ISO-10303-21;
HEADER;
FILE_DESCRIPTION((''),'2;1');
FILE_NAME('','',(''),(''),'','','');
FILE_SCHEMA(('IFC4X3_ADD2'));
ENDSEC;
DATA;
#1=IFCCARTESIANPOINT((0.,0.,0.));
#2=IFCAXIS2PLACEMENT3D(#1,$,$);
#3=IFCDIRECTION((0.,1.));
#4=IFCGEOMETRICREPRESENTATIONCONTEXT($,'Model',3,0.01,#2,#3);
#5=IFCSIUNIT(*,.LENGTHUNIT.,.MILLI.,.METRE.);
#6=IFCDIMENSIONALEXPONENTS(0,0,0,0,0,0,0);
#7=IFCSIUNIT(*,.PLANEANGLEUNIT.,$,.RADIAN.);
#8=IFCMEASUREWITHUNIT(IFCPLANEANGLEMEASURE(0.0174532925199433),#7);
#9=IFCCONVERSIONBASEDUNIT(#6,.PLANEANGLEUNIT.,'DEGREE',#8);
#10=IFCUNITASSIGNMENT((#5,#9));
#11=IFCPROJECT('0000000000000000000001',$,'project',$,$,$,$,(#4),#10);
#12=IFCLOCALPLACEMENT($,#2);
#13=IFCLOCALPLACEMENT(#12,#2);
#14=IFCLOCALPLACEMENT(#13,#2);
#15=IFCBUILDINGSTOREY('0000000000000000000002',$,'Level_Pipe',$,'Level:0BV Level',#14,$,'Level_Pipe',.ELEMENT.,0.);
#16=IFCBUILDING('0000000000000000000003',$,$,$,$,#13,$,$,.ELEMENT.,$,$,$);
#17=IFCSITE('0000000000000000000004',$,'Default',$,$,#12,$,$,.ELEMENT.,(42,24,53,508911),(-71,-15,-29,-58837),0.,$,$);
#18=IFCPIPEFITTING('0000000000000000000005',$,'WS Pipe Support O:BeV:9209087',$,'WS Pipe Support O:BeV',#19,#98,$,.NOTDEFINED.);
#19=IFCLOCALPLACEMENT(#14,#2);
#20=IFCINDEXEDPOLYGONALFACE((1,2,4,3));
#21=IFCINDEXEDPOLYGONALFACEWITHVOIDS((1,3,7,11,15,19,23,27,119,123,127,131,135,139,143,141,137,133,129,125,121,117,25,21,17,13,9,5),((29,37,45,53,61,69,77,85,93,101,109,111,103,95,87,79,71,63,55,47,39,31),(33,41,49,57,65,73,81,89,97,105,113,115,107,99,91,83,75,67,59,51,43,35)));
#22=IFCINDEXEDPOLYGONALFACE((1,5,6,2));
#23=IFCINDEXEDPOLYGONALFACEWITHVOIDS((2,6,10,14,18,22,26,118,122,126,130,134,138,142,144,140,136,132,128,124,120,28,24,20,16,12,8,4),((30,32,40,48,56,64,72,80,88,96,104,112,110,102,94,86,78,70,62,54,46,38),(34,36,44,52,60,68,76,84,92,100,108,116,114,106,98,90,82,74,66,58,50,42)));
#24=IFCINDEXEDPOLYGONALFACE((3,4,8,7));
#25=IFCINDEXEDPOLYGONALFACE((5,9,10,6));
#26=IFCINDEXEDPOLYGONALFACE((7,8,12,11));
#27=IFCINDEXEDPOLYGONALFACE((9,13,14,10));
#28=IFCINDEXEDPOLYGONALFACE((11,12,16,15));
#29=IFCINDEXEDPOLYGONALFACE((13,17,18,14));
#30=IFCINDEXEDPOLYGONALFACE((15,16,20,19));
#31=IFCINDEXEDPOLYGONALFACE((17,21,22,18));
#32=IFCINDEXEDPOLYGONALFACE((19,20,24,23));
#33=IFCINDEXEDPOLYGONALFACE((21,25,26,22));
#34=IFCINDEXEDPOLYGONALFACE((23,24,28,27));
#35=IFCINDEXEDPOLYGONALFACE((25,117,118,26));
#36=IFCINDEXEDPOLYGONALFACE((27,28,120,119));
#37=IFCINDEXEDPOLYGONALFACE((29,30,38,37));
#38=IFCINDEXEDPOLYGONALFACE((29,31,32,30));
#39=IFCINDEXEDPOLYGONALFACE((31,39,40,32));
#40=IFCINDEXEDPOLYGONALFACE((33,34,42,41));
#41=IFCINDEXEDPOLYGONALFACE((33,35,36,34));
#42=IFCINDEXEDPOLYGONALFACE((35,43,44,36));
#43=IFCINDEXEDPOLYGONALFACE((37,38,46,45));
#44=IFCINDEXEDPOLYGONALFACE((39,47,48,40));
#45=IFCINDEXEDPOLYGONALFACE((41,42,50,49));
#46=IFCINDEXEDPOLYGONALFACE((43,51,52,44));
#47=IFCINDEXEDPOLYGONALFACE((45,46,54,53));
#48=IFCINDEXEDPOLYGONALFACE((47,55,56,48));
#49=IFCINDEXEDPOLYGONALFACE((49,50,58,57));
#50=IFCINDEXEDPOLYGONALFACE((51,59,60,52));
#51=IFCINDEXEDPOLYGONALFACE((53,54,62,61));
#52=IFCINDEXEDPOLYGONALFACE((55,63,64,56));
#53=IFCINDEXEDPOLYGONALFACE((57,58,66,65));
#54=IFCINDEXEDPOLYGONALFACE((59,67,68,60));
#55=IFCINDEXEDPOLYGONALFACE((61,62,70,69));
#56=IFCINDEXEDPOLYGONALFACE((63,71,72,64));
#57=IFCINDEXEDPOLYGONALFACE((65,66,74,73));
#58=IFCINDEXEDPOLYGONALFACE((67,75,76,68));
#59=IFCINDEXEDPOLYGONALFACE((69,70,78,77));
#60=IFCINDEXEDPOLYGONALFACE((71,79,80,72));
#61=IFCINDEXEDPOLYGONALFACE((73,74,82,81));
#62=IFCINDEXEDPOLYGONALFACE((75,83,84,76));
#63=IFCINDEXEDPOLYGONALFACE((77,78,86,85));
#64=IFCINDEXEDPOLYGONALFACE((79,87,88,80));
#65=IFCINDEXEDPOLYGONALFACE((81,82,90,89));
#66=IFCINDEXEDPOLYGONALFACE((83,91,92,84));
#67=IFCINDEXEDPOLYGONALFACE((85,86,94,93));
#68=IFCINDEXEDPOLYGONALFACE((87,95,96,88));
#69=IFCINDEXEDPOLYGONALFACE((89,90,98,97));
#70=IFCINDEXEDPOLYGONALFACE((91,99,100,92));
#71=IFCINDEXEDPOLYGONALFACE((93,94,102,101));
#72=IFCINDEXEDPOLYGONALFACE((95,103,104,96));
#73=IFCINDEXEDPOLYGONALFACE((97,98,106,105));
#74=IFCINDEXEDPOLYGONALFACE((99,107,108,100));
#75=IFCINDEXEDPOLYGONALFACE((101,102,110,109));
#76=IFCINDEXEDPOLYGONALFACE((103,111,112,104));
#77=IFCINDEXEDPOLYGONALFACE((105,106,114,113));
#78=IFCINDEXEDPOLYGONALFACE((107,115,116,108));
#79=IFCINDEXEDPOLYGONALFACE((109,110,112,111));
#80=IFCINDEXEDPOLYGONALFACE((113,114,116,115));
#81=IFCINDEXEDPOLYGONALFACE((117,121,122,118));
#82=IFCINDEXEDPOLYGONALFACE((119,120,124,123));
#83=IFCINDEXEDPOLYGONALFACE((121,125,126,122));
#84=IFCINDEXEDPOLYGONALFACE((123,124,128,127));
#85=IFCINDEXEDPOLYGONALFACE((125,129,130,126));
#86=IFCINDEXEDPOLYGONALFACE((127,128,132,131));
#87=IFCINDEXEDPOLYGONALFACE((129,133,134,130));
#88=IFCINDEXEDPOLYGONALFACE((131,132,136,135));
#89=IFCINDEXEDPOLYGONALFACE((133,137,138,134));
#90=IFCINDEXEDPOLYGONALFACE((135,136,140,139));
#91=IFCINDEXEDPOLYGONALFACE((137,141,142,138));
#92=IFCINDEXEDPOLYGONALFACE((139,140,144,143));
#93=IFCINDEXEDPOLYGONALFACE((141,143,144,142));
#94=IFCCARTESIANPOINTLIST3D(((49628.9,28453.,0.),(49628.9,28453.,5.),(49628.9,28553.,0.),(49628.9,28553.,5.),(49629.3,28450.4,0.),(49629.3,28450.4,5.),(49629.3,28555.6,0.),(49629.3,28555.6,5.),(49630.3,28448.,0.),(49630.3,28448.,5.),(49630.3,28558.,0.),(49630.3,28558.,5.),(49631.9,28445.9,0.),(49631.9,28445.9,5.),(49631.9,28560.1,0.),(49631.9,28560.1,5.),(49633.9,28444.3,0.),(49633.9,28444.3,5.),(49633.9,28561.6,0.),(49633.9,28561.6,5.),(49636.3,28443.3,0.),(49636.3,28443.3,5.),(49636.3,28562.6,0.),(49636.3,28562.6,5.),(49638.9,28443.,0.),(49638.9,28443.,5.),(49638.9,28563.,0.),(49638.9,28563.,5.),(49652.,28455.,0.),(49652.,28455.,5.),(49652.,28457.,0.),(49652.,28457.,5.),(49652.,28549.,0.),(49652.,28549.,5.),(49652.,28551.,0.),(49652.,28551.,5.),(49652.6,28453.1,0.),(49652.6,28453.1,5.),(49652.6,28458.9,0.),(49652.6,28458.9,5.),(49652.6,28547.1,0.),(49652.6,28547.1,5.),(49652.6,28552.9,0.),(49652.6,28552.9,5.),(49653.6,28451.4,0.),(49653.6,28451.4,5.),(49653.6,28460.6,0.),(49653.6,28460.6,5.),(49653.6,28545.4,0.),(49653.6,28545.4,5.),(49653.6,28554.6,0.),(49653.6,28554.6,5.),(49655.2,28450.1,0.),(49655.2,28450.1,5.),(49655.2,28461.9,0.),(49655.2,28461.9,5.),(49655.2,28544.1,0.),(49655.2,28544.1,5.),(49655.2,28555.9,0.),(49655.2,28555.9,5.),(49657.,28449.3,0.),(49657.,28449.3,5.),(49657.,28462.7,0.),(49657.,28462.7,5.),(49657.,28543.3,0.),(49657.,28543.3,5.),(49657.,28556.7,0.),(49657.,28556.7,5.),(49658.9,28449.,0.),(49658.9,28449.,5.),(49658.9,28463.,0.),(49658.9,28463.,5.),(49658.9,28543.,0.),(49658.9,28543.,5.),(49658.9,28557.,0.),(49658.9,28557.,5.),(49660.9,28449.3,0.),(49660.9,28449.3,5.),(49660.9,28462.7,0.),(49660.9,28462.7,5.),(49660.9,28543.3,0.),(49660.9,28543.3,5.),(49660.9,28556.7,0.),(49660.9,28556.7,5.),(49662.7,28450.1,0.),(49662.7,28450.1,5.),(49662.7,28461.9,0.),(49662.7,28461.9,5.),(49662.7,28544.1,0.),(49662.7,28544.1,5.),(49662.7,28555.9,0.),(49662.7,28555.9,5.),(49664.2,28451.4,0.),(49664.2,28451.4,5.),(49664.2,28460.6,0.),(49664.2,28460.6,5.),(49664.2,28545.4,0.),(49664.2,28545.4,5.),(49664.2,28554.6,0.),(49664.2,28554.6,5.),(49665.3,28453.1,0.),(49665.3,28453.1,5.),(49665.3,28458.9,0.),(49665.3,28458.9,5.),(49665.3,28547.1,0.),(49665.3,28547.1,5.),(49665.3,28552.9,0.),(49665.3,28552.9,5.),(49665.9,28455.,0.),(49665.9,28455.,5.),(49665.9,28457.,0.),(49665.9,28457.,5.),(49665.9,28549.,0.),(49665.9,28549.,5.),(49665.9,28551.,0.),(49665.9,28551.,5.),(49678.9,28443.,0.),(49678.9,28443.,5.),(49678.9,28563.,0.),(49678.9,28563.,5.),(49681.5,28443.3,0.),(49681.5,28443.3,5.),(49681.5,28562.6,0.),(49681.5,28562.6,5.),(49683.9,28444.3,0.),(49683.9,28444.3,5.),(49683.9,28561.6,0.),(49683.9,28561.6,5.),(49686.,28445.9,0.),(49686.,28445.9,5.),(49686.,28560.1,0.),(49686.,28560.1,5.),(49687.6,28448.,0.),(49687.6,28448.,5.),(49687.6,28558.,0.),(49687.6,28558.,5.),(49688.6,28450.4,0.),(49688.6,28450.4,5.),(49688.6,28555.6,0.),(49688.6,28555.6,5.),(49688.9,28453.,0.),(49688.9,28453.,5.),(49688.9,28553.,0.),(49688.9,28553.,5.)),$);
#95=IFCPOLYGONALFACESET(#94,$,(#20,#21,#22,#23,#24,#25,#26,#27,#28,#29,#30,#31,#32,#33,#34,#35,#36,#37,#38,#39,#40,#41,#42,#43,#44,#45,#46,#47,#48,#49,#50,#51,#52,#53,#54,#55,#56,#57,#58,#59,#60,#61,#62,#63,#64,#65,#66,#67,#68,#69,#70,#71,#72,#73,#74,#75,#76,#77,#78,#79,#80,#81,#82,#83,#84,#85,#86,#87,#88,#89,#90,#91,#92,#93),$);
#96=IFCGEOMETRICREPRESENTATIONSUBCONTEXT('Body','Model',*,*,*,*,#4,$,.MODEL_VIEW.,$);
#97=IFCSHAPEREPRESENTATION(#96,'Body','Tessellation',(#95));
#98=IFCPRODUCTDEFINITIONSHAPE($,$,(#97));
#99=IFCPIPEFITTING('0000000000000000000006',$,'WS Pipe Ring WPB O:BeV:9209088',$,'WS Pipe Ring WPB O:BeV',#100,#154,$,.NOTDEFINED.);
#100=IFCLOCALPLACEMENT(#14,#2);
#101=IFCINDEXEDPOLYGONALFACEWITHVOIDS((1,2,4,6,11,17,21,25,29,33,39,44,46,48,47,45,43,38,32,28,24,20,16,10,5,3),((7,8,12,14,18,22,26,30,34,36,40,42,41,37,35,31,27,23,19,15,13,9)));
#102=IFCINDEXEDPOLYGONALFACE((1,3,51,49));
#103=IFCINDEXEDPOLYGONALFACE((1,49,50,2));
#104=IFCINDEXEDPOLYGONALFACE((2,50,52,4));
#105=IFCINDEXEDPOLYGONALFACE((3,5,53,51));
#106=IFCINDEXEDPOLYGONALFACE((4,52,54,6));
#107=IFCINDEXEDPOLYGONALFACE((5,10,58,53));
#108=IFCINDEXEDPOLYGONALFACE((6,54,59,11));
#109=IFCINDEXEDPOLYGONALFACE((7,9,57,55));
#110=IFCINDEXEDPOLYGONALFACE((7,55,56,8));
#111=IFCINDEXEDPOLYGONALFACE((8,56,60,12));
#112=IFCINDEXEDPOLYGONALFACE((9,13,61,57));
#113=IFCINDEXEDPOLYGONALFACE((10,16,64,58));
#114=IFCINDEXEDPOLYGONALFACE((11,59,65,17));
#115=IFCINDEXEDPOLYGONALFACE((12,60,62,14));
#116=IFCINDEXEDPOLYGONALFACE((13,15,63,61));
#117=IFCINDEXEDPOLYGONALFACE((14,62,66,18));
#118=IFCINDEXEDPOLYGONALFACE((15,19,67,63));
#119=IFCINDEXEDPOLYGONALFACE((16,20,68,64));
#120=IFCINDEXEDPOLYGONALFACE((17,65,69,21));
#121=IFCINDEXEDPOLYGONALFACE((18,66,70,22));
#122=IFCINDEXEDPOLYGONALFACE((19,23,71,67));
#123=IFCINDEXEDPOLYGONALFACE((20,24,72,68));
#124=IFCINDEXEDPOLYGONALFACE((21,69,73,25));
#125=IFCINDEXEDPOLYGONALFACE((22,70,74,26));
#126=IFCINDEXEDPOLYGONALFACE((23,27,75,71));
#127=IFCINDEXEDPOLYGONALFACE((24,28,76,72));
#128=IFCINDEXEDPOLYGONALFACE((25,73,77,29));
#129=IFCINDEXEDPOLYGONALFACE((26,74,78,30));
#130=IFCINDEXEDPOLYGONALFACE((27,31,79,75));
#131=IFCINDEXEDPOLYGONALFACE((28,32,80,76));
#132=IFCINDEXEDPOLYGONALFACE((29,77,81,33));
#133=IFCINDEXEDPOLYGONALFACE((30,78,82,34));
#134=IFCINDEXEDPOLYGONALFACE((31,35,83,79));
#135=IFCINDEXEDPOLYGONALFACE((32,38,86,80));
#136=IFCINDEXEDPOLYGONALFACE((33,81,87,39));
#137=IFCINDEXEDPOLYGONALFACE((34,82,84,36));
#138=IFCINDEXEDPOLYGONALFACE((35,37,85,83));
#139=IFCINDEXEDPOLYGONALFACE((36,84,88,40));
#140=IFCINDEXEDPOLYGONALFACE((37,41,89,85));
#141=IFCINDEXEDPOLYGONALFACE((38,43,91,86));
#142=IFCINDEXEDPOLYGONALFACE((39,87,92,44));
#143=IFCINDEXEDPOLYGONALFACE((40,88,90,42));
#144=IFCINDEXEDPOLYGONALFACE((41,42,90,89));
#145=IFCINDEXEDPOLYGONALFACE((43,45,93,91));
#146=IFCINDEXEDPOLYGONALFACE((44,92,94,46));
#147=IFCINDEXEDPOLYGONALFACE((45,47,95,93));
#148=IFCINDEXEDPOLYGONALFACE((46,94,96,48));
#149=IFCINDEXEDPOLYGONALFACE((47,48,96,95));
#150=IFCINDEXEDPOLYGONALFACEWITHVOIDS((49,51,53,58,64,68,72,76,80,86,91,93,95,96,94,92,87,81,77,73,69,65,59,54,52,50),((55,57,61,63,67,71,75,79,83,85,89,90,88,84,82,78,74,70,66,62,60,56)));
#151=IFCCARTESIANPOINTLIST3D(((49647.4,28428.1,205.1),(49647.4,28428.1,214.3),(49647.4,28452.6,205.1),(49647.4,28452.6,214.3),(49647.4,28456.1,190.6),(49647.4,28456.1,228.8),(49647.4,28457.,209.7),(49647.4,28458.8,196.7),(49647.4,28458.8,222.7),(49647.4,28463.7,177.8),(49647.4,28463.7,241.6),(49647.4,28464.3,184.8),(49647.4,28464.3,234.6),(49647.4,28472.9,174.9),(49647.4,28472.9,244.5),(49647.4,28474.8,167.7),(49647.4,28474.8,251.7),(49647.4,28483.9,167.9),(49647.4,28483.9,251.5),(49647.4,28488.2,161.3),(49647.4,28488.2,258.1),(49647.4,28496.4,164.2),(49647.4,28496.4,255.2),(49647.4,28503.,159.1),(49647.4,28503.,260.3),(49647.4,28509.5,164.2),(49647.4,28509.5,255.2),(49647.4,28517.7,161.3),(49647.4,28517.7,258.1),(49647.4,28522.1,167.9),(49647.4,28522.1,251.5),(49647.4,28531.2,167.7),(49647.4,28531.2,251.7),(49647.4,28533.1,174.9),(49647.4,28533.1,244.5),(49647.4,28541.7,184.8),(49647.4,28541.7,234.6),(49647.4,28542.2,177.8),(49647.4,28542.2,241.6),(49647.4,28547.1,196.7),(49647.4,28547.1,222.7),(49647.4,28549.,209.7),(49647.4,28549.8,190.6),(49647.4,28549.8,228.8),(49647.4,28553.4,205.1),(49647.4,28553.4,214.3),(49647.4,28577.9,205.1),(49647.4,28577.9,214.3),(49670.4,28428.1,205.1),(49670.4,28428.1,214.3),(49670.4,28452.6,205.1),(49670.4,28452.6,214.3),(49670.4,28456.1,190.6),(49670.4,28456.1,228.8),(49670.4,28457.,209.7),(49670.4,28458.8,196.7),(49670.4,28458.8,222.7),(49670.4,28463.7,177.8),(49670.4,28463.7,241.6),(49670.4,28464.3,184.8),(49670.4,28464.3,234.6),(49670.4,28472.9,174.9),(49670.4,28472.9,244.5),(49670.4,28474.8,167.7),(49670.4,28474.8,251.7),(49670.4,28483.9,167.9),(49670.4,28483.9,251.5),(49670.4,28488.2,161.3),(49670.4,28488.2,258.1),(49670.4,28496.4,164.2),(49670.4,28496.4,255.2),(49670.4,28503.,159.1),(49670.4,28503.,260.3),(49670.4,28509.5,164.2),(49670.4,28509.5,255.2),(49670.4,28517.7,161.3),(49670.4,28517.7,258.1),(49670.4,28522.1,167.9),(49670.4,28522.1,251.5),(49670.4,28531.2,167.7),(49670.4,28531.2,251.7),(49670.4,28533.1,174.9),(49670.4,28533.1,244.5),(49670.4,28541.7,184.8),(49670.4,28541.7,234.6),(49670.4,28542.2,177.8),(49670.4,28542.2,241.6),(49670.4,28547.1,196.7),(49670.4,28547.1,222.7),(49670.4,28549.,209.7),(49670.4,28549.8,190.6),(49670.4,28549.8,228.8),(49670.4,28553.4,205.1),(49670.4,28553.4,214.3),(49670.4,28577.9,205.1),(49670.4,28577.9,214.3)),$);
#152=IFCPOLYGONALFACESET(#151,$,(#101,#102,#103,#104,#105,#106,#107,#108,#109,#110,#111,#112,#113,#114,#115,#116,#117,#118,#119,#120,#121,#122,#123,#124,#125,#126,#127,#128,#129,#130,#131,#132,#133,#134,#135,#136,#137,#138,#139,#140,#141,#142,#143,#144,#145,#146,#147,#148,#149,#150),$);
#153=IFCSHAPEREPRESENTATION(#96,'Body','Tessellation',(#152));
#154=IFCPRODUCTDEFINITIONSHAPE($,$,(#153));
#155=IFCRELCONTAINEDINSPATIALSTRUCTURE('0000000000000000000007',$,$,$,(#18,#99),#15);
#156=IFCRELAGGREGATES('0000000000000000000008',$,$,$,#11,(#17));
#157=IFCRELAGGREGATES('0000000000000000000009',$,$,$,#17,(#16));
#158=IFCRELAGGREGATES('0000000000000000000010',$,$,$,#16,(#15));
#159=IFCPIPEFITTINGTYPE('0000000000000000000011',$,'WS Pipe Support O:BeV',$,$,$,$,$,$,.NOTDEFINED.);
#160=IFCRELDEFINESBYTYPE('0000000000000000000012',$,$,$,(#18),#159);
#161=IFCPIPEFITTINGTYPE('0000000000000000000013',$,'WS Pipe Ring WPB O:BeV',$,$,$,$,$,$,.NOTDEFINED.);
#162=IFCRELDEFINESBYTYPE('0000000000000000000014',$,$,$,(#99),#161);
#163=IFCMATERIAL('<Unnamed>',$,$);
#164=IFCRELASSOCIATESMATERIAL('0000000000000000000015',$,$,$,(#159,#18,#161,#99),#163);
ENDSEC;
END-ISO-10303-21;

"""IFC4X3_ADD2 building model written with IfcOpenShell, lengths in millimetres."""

from ifc_helpers import new_model, entity, si_unit, converted_unit, direction, frame, frame_2d, origin, origin_2d_with_axis, place, context, subcontext, project, spatial, polyline, circle_curve, parameter, trimmed, segment, composite_curve, outline, extrude, source, transform, mapped, material, type_object, type_shapes, element, save


model = new_model("IFC4X3_ADD2")

# Units and contexts
model_context = context("Model", 3, precision=0.01, world=origin(), true_north=direction((0.0, 1.0)))
body_context = subcontext(model_context, "Body", "Model", "MODEL_VIEW")
ifc_project = project(units=[si_unit("LENGTHUNIT", "METRE", prefix="MILLI"), converted_unit("PLANEANGLEUNIT", "DEGREE", entity("IfcPlaneAngleMeasure", 0.0174532925199433), si_unit("PLANEANGLEUNIT", "RADIAN"), dimensions=[0, 0, 0, 0, 0, 0, 0])], contexts=[model_context])

# Site, building, storey
site_placement = place(None, origin())
site = spatial("IfcSite", under=ifc_project, at=site_placement, Name="Default", CompositionType="ELEMENT", RefLatitude=(42, 24, 53, 508911), RefLongitude=(-71, -15, -29, -58837), RefElevation=0.0)
building_placement = place(site_placement, origin())
building = spatial("IfcBuilding", under=site, at=building_placement, CompositionType="ELEMENT")
storey_placement = place(building_placement, origin())
storey = spatial("IfcBuildingStorey", under=building, at=storey_placement, Name="Level_Pipe", ObjectType="Level:0BV Level", LongName="Level_Pipe", CompositionType="ELEMENT", Elevation=0.0)

# Pipe fittings
ifc_material_1 = material(Name="<Unnamed>")
pipe_fitting_type_1 = type_object("IfcPipeFittingType", Name="WS Pipe Support O:BeV", PredefinedType="NOTDEFINED", material=ifc_material_1)
shared_shape_1 = source(origin(), body_context, "Body", "SweptSolid", [
    extrude(outline(composite_curve([segment(trimmed(circle_curve(frame_2d((50.0, -20.0), x_axis=(1.0, 0.0)), 10.0), [parameter(270.0)], [parameter(0.0)], True, "PARAMETER"), True, "CONTINUOUS"), segment(polyline([(60.0, -20.0), (60.0, 20.0)]), True, "CONTINUOUS"), segment(trimmed(circle_curve(frame_2d((50.0, 20.0), x_axis=(1.0, 0.0)), 10.0), [parameter(0.0)], [parameter(90.0)], True, "PARAMETER"), True, "CONTINUOUS"), segment(polyline([(50.0, 30.0), (-50.0, 30.0)]), True, "CONTINUOUS"), segment(trimmed(circle_curve(frame_2d((-50.0, 20.0), x_axis=(1.0, 0.0)), 10.0), [parameter(90.0)], [parameter(180.0)], True, "PARAMETER"), True, "CONTINUOUS"), segment(polyline([(-60.0, 20.0), (-60.0, -20.0)]), True, "CONTINUOUS"), segment(trimmed(circle_curve(frame_2d((-50.0, -20.0), x_axis=(1.0, 0.0)), 10.0), [parameter(180.0)], [parameter(270.0)], True, "PARAMETER"), True, "CONTINUOUS"), segment(polyline([(-50.0, -30.0), (50.0, -30.0)]), True, "CONTINUOUS")], self_intersect=False), holes=[composite_curve([segment(trimmed(circle_curve(frame_2d((-47.0, 0.0), x_axis=(1.0, 0.0)), 7.0), [parameter(0.0)], [parameter(180.0)], True, "PARAMETER"), False, "CONTINUOUS"), segment(trimmed(circle_curve(frame_2d((-47.0, 0.0), x_axis=(1.0, 0.0)), 7.0), [parameter(180.0)], [parameter(360.0)], True, "PARAMETER"), False, "CONTINUOUS")], self_intersect=False), composite_curve([segment(trimmed(circle_curve(frame_2d((47.0, 0.0), x_axis=(1.0, 0.0)), 7.0), [parameter(0.0)], [parameter(180.0)], True, "PARAMETER"), False, "CONTINUOUS"), segment(trimmed(circle_curve(frame_2d((47.0, 0.0), x_axis=(1.0, 0.0)), 7.0), [parameter(180.0)], [parameter(360.0)], True, "PARAMETER"), False, "CONTINUOUS")], self_intersect=False)]), origin(), (0.0, 0.0, 1.0), 5.0),
])
type_shapes(pipe_fitting_type_1, [shared_shape_1])
pipe_fitting_1_placement = place(storey_placement, frame((49658.9, 28503.0, 0.0), z_axis=(0.0, 0.0, 1.0), x_axis=(0.0, -1.0, 0.0)))
element("IfcPipeFitting", 1, at=pipe_fitting_1_placement, inside=storey, type_object=pipe_fitting_type_1, material=ifc_material_1, Name="WS Pipe Support O:BeV:9209087", ObjectType="WS Pipe Support O:BeV", PredefinedType="NOTDEFINED", context=body_context, shape_type="MappedRepresentation", body=[
    mapped(shared_shape_1, transform((0.0, 0.0, 0.0), scale=1.0)),
])
pipe_fitting_type_2 = type_object("IfcPipeFittingType", Name="WS Pipe Ring WPB O:BeV", PredefinedType="NOTDEFINED", material=ifc_material_1)
shared_shape_2 = source(origin(), body_context, "Body", "SweptSolid", [
    extrude(outline(composite_curve([segment(trimmed(circle_curve(origin_2d_with_axis(), 50.6), [parameter(185.215909)], [parameter(354.784091)], True, "PARAMETER"), True, "CONTINUOUS"), segment(polyline([(50.4, -4.6), (74.9, -4.6)]), True, "CONTINUOUS"), segment(polyline([(74.9, -4.6), (74.9, 4.6)]), True, "CONTINUOUS"), segment(polyline([(74.9, 4.6), (50.4, 4.6)]), True, "CONTINUOUS"), segment(trimmed(circle_curve(origin_2d_with_axis(), 50.6), [parameter(5.215909)], [parameter(174.784091)], True, "PARAMETER"), True, "CONTINUOUS"), segment(polyline([(-50.4, 4.6), (-74.9, 4.6)]), True, "CONTINUOUS"), segment(polyline([(-74.9, 4.6), (-74.9, -4.6)]), True, "CONTINUOUS"), segment(polyline([(-74.9, -4.6), (-50.4, -4.6)]), True, "CONTINUOUS")], self_intersect=False), holes=[composite_curve([segment(trimmed(circle_curve(origin_2d_with_axis(), 46.0), [parameter(0.0)], [parameter(180.0)], True, "PARAMETER"), False, "CONTINUOUS"), segment(trimmed(circle_curve(origin_2d_with_axis(), 46.0), [parameter(180.0)], [parameter(360.0)], True, "PARAMETER"), False, "CONTINUOUS")], self_intersect=False)]), frame((0.0, -11.5, 0.0), z_axis=(0.0, 1.0, 0.0), x_axis=(1.0, 0.0, 0.0)), (0.0, 0.0, 1.0), 23.0),
])
type_shapes(pipe_fitting_type_2, [shared_shape_2])
pipe_fitting_2_placement = place(storey_placement, frame((49658.9, 28503.0, 209.7), z_axis=(0.0, 0.0, 1.0), x_axis=(0.0, -1.0, 0.0)))
element("IfcPipeFitting", 2, at=pipe_fitting_2_placement, inside=storey, type_object=pipe_fitting_type_2, material=ifc_material_1, Name="WS Pipe Ring WPB O:BeV:9209088", ObjectType="WS Pipe Ring WPB O:BeV", PredefinedType="NOTDEFINED", context=body_context, shape_type="MappedRepresentation", body=[
    mapped(shared_shape_2, transform((0.0, 0.0, 0.0), scale=1.0)),
])

save(model, "model.ifc")
